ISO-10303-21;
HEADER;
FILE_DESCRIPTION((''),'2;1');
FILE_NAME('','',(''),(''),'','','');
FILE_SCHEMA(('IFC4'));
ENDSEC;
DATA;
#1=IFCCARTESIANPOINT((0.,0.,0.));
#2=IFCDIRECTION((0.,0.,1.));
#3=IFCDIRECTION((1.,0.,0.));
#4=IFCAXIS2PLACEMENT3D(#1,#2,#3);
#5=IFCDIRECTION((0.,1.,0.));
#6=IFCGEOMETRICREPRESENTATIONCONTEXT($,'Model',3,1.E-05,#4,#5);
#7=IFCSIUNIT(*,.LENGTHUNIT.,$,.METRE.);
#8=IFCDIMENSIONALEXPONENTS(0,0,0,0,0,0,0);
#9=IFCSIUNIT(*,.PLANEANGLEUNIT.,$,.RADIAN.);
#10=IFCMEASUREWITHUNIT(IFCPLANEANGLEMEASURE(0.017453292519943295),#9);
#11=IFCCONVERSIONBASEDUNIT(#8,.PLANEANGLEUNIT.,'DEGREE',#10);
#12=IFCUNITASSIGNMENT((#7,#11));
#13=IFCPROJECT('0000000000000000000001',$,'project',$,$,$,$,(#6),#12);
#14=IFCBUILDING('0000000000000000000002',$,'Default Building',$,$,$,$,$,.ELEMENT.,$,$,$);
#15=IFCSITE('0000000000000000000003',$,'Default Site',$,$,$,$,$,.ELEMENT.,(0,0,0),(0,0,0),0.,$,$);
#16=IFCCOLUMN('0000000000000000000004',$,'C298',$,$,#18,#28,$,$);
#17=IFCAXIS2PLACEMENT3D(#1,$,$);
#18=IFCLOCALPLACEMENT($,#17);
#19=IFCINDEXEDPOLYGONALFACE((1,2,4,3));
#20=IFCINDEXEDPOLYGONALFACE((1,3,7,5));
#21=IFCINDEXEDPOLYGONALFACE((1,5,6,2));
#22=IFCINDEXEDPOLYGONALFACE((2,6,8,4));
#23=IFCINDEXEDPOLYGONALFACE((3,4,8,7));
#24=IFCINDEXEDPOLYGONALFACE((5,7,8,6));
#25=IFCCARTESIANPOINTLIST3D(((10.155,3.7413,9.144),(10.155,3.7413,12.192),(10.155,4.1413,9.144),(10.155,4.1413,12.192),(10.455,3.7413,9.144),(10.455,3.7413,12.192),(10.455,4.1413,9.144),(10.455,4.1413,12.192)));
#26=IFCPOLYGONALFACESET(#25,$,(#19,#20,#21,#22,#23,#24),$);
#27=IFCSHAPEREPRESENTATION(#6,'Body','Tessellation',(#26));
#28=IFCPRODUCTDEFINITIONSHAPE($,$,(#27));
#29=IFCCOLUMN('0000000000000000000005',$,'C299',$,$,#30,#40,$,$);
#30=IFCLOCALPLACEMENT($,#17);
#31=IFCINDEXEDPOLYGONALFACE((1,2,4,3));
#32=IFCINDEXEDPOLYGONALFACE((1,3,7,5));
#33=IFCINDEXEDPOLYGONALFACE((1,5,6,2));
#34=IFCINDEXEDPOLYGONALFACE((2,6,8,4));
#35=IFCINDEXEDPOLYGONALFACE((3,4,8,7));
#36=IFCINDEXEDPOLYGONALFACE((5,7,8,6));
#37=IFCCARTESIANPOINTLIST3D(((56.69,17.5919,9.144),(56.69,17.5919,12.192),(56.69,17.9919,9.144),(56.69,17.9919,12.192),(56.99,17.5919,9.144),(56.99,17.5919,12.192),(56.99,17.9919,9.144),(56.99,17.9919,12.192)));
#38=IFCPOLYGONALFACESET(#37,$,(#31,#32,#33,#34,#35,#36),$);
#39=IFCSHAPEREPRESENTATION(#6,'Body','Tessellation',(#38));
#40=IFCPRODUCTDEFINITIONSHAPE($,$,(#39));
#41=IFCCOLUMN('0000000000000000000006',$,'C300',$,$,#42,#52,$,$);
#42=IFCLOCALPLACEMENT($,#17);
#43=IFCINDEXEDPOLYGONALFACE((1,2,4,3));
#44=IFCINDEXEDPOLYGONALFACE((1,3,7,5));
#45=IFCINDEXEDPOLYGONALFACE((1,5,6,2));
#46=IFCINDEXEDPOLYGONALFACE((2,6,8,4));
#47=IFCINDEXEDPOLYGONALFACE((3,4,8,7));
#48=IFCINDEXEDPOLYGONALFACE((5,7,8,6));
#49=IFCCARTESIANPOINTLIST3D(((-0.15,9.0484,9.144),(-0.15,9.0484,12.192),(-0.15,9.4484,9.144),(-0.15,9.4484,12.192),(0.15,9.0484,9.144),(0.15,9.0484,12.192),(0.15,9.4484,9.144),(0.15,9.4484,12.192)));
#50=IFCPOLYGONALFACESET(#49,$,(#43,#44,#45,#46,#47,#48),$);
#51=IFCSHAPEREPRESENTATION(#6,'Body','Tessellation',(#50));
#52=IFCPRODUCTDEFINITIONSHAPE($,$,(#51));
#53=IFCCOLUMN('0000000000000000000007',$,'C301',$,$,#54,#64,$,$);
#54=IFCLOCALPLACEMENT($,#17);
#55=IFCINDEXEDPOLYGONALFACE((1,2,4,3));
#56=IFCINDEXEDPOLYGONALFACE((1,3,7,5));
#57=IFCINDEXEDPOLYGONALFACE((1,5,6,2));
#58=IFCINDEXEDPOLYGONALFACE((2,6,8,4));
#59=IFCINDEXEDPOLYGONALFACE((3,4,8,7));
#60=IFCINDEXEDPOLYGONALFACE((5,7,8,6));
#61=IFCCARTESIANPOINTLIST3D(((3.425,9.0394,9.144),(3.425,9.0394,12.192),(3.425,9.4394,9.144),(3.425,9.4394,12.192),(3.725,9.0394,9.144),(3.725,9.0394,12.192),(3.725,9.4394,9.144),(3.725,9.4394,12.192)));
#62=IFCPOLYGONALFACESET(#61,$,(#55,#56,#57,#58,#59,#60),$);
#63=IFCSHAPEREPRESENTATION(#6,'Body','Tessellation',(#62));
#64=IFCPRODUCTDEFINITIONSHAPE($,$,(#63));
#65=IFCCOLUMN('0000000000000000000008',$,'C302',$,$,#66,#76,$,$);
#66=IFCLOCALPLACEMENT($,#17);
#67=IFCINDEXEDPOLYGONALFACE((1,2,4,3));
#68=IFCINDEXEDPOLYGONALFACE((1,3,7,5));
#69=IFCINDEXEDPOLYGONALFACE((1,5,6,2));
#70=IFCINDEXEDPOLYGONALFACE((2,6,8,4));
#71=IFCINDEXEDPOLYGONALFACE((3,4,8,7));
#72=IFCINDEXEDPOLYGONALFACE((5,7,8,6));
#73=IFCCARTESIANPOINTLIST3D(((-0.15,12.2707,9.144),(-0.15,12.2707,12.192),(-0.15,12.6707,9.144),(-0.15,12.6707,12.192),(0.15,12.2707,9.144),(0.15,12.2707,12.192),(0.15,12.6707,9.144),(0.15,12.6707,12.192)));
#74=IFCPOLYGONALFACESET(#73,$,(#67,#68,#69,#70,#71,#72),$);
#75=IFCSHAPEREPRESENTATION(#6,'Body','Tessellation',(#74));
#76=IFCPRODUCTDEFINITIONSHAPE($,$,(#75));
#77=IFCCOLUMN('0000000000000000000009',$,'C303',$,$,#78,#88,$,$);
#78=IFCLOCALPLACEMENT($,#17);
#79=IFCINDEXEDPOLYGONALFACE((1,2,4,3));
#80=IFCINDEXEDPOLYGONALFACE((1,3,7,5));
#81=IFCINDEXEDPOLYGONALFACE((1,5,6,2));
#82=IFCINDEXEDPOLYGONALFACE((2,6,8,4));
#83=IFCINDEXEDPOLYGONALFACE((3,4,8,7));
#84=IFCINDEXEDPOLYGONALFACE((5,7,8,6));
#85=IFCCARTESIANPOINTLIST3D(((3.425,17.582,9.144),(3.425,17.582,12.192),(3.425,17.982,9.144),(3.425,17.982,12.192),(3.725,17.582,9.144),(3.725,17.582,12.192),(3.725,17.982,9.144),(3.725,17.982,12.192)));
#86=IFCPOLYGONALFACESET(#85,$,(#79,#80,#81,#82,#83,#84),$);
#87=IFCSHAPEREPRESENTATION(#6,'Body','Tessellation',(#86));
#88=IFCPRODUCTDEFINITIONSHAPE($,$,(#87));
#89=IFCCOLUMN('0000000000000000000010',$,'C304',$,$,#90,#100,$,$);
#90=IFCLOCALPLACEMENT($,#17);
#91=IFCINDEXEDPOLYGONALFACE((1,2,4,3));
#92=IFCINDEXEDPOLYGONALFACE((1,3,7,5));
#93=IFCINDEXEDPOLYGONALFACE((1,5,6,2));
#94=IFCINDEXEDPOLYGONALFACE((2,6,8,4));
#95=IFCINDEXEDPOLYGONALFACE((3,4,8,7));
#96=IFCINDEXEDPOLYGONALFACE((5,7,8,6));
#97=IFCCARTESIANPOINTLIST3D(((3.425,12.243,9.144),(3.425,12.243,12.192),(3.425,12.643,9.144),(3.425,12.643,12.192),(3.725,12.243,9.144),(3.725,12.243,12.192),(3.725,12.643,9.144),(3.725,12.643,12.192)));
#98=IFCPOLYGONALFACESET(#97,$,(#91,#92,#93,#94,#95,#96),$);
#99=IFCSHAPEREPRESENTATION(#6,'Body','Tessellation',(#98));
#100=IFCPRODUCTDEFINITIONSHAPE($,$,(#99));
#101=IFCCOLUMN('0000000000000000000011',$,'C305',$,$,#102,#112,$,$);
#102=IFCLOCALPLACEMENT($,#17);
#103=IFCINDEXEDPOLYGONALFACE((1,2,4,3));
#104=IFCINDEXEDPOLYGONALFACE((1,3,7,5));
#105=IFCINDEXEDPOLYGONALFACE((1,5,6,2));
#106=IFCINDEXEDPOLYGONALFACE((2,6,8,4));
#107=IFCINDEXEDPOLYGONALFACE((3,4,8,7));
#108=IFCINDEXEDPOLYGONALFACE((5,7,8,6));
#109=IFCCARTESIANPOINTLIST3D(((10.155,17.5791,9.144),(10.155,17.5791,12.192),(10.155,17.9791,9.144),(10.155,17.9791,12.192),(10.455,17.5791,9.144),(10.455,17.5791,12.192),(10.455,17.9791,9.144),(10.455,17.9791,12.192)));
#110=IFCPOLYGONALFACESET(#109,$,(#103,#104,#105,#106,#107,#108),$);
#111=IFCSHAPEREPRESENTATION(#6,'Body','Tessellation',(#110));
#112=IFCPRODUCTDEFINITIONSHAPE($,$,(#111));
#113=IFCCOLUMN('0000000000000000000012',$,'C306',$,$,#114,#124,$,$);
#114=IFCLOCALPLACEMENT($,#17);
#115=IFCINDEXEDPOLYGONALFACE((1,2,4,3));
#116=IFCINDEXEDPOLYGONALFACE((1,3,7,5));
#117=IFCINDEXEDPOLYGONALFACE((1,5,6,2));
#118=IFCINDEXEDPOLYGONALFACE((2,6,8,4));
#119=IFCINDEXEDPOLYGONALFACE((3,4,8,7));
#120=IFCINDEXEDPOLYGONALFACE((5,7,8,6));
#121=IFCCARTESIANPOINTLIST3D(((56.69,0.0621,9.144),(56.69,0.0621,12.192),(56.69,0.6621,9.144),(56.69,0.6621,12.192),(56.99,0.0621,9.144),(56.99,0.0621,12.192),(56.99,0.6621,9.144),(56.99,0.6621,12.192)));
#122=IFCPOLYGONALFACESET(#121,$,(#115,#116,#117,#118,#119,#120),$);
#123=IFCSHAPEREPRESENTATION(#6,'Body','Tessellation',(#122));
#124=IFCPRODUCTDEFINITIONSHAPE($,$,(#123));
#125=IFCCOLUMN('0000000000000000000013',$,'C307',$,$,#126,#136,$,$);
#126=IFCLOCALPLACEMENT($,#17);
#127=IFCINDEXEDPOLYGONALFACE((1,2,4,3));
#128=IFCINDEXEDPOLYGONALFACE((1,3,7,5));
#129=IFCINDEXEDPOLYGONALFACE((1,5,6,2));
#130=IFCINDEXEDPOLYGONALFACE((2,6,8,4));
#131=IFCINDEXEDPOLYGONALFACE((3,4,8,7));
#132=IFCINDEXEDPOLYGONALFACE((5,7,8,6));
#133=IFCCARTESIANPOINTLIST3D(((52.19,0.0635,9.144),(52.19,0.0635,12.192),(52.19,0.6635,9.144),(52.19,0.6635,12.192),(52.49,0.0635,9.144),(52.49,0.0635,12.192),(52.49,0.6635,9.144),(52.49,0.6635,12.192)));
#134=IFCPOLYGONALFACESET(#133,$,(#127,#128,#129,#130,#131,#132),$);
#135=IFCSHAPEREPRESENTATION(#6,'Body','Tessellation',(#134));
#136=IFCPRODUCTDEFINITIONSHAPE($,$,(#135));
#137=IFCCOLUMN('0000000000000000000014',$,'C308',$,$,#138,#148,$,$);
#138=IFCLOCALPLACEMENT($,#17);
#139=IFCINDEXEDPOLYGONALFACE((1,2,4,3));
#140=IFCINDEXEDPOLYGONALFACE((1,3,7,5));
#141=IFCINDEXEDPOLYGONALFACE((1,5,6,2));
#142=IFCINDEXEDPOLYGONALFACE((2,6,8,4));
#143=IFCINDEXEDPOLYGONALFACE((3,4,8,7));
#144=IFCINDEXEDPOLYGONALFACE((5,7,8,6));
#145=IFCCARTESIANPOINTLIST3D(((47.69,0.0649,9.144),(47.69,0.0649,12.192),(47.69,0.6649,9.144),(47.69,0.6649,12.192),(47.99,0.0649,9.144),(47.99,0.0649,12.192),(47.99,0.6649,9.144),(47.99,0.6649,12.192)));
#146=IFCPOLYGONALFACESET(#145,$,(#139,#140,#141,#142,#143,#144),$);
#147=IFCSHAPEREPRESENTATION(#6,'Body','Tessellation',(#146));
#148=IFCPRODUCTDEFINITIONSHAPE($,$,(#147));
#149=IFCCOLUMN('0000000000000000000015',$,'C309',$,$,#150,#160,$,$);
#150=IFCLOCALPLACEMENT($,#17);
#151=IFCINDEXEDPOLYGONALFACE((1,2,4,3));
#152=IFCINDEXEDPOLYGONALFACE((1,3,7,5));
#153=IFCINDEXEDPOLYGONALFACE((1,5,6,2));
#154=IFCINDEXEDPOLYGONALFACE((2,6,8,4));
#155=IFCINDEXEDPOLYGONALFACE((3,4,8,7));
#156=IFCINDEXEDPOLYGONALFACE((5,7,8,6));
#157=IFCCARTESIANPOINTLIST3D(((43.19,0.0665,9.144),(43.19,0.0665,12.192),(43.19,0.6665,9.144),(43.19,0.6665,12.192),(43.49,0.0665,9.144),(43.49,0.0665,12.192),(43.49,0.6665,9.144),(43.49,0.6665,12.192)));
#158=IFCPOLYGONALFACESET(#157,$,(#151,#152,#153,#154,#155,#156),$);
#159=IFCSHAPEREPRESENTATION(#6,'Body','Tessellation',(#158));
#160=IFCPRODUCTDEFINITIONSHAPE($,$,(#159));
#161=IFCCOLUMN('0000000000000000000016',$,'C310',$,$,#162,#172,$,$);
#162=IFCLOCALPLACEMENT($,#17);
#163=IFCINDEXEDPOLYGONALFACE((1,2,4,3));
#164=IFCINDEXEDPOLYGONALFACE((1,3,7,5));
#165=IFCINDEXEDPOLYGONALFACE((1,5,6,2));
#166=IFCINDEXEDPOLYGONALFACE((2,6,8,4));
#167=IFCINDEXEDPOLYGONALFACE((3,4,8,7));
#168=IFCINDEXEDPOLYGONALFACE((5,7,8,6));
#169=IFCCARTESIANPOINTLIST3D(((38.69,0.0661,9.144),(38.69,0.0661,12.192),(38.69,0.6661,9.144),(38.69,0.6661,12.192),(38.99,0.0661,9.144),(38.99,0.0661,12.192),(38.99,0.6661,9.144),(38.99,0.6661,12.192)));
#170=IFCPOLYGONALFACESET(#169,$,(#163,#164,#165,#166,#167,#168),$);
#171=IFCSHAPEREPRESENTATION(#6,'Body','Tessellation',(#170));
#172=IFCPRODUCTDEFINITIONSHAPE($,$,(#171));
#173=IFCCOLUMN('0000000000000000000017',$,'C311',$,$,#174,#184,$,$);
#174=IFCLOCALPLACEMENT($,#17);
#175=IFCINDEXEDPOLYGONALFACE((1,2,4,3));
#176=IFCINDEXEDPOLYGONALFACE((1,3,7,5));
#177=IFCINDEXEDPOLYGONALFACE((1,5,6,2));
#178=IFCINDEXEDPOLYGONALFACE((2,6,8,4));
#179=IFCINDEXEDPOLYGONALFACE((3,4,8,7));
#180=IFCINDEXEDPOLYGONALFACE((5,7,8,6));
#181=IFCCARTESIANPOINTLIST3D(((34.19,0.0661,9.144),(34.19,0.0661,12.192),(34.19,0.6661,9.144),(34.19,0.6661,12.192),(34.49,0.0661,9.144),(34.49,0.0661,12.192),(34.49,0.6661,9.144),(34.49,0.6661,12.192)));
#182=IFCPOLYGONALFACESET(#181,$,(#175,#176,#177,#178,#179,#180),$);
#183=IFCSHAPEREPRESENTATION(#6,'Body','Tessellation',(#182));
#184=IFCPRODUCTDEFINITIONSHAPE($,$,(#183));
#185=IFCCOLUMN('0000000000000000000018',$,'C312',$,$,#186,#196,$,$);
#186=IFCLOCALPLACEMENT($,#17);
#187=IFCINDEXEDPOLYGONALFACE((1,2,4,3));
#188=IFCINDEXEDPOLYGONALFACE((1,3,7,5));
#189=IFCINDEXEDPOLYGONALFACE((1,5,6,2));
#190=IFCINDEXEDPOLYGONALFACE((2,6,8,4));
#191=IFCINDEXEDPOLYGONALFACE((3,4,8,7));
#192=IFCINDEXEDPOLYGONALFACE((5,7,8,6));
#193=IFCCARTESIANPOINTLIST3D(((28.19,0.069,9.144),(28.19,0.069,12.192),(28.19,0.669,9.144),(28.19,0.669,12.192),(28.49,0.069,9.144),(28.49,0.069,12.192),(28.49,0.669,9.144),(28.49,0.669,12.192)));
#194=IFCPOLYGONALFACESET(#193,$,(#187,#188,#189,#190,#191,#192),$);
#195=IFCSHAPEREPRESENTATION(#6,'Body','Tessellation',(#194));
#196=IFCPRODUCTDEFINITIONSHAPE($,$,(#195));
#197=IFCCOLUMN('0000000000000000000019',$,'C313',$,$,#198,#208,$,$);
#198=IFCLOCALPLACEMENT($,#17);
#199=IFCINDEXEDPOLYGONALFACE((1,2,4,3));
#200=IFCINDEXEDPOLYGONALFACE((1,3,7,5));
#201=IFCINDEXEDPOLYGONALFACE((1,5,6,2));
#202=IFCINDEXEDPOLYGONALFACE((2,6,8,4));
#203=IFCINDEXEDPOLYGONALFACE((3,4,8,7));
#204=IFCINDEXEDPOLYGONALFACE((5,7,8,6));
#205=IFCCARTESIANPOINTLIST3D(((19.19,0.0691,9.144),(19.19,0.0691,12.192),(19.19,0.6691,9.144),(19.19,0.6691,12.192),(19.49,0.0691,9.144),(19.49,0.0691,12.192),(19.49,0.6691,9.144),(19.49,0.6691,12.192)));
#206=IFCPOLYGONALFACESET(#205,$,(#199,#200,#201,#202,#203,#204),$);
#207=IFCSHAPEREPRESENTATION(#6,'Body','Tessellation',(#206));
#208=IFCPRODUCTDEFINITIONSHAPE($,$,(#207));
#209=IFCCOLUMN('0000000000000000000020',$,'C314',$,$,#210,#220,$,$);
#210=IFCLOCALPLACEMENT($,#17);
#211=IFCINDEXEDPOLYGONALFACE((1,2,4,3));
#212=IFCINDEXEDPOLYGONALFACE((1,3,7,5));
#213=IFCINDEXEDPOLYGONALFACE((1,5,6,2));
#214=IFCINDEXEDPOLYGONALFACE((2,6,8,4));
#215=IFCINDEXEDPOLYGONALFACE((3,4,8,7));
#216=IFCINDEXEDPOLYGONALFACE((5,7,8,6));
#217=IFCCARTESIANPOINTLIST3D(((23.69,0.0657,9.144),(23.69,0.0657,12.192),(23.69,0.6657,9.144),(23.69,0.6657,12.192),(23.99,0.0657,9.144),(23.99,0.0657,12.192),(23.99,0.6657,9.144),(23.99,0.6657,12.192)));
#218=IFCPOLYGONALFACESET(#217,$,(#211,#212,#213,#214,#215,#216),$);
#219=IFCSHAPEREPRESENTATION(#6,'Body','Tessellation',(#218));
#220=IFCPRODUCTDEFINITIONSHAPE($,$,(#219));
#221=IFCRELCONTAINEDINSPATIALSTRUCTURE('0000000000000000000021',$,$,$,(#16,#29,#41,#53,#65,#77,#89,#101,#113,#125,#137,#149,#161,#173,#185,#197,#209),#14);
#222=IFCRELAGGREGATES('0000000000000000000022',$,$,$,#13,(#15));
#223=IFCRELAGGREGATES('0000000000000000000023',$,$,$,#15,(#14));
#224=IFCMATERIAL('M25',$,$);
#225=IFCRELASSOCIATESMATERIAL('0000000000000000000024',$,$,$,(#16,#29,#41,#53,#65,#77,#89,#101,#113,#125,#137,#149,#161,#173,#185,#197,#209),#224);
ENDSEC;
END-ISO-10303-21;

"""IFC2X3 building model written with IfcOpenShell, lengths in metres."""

from ifc_helpers import new_model, entity, si_unit, converted_unit, direction, frame, frame_2d, origin_with_axes, place, context, project, spatial, rectangle, extrude, material, element, save


model = new_model("IFC2X3")

# Units and contexts
model_context = context("Model", 3, precision=1e-05, world=origin_with_axes(), true_north=direction((0.0, 1.0, 0.0)))
ifc_project = project(units=[si_unit("LENGTHUNIT", "METRE"), converted_unit("PLANEANGLEUNIT", "DEGREE", entity("IfcPlaneAngleMeasure", 0.017453292519943295), si_unit("PLANEANGLEUNIT", "RADIAN"), dimensions=[0, 0, 0, 0, 0, 0, 0])], contexts=[model_context])

# Site, building
site = spatial("IfcSite", under=ifc_project, Name="Default Site", CompositionType="ELEMENT", RefLatitude=(0, 0, 0), RefLongitude=(0, 0, 0), RefElevation=0.0)
building = spatial("IfcBuilding", under=site, Name="Default Building", CompositionType="ELEMENT")

# Columns
ifc_material = material(Name="M25")
placement = place(None, origin_with_axes())
element("IfcColumn", 1, at=placement, inside=building, material=ifc_material, Name="C298", context=model_context, shape_type="SweptSolid", body=[
    extrude(rectangle(XDim=0.3, YDim=0.4, at=frame_2d((0.0, 0.0), x_axis=(1.0, 0.0, 0.0))), frame((10.305, 3.9413, 9.144), z_axis=(0.0, 0.0, 1.0), x_axis=(1.0, 0.0, 0.0)), (0.0, 0.0, 1.0), 3.048),
])
element("IfcColumn", 2, at=placement, inside=building, material=ifc_material, Name="C299", context=model_context, shape_type="SweptSolid", body=[
    extrude(rectangle(XDim=0.3, YDim=0.4, at=frame_2d((0.0, 0.0), x_axis=(1.0, 0.0, 0.0))), frame((56.84, 17.7919, 9.144), z_axis=(0.0, 0.0, 1.0), x_axis=(1.0, 0.0, 0.0)), (0.0, 0.0, 1.0), 3.048),
])
element("IfcColumn", 3, at=placement, inside=building, material=ifc_material, Name="C300", context=model_context, shape_type="SweptSolid", body=[
    extrude(rectangle(XDim=0.3, YDim=0.4, at=frame_2d((0.0, 0.0), x_axis=(1.0, 0.0, 0.0))), frame((0.0, 9.2484, 9.144), z_axis=(0.0, 0.0, 1.0), x_axis=(1.0, 0.0, 0.0)), (0.0, 0.0, 1.0), 3.048),
])
element("IfcColumn", 4, at=placement, inside=building, material=ifc_material, Name="C301", context=model_context, shape_type="SweptSolid", body=[
    extrude(rectangle(XDim=0.3, YDim=0.4, at=frame_2d((0.0, 0.0), x_axis=(1.0, 0.0, 0.0))), frame((3.575, 9.2394, 9.144), z_axis=(0.0, 0.0, 1.0), x_axis=(1.0, 0.0, 0.0)), (0.0, 0.0, 1.0), 3.048),
])
element("IfcColumn", 5, at=placement, inside=building, material=ifc_material, Name="C302", context=model_context, shape_type="SweptSolid", body=[
    extrude(rectangle(XDim=0.3, YDim=0.4, at=frame_2d((0.0, 0.0), x_axis=(1.0, 0.0, 0.0))), frame((0.0, 12.4707, 9.144), z_axis=(0.0, 0.0, 1.0), x_axis=(1.0, 0.0, 0.0)), (0.0, 0.0, 1.0), 3.048),
])
element("IfcColumn", 6, at=placement, inside=building, material=ifc_material, Name="C303", context=model_context, shape_type="SweptSolid", body=[
    extrude(rectangle(XDim=0.3, YDim=0.4, at=frame_2d((0.0, 0.0), x_axis=(1.0, 0.0, 0.0))), frame((3.575, 17.782, 9.144), z_axis=(0.0, 0.0, 1.0), x_axis=(1.0, 0.0, 0.0)), (0.0, 0.0, 1.0), 3.048),
])
element("IfcColumn", 7, at=placement, inside=building, material=ifc_material, Name="C304", context=model_context, shape_type="SweptSolid", body=[
    extrude(rectangle(XDim=0.3, YDim=0.4, at=frame_2d((0.0, 0.0), x_axis=(1.0, 0.0, 0.0))), frame((3.575, 12.443, 9.144), z_axis=(0.0, 0.0, 1.0), x_axis=(1.0, 0.0, 0.0)), (0.0, 0.0, 1.0), 3.048),
])
element("IfcColumn", 8, at=placement, inside=building, material=ifc_material, Name="C305", context=model_context, shape_type="SweptSolid", body=[
    extrude(rectangle(XDim=0.3, YDim=0.4, at=frame_2d((0.0, 0.0), x_axis=(1.0, 0.0, 0.0))), frame((10.305, 17.7791, 9.144), z_axis=(0.0, 0.0, 1.0), x_axis=(1.0, 0.0, 0.0)), (0.0, 0.0, 1.0), 3.048),
])
element("IfcColumn", 9, at=placement, inside=building, material=ifc_material, Name="C306", context=model_context, shape_type="SweptSolid", body=[
    extrude(rectangle(XDim=0.3, YDim=0.6, at=frame_2d((0.0, 0.0), x_axis=(1.0, 0.0, 0.0))), frame((56.84, 0.3621, 9.144), z_axis=(0.0, 0.0, 1.0), x_axis=(1.0, 0.0, 0.0)), (0.0, 0.0, 1.0), 3.048),
])
element("IfcColumn", 10, at=placement, inside=building, material=ifc_material, Name="C307", context=model_context, shape_type="SweptSolid", body=[
    extrude(rectangle(XDim=0.3, YDim=0.6, at=frame_2d((0.0, 0.0), x_axis=(1.0, 0.0, 0.0))), frame((52.34, 0.3635, 9.144), z_axis=(0.0, 0.0, 1.0), x_axis=(1.0, 0.0, 0.0)), (0.0, 0.0, 1.0), 3.048),
])
element("IfcColumn", 11, at=placement, inside=building, material=ifc_material, Name="C308", context=model_context, shape_type="SweptSolid", body=[
    extrude(rectangle(XDim=0.3, YDim=0.6, at=frame_2d((0.0, 0.0), x_axis=(1.0, 0.0, 0.0))), frame((47.84, 0.3649, 9.144), z_axis=(0.0, 0.0, 1.0), x_axis=(1.0, 0.0, 0.0)), (0.0, 0.0, 1.0), 3.048),
])
element("IfcColumn", 12, at=placement, inside=building, material=ifc_material, Name="C309", context=model_context, shape_type="SweptSolid", body=[
    extrude(rectangle(XDim=0.3, YDim=0.6, at=frame_2d((0.0, 0.0), x_axis=(1.0, 0.0, 0.0))), frame((43.34, 0.3665, 9.144), z_axis=(0.0, 0.0, 1.0), x_axis=(1.0, 0.0, 0.0)), (0.0, 0.0, 1.0), 3.048),
])
element("IfcColumn", 13, at=placement, inside=building, material=ifc_material, Name="C310", context=model_context, shape_type="SweptSolid", body=[
    extrude(rectangle(XDim=0.3, YDim=0.6, at=frame_2d((0.0, 0.0), x_axis=(1.0, 0.0, 0.0))), frame((38.84, 0.3661, 9.144), z_axis=(0.0, 0.0, 1.0), x_axis=(1.0, 0.0, 0.0)), (0.0, 0.0, 1.0), 3.048),
])
element("IfcColumn", 14, at=placement, inside=building, material=ifc_material, Name="C311", context=model_context, shape_type="SweptSolid", body=[
    extrude(rectangle(XDim=0.3, YDim=0.6, at=frame_2d((0.0, 0.0), x_axis=(1.0, 0.0, 0.0))), frame((34.34, 0.3661, 9.144), z_axis=(0.0, 0.0, 1.0), x_axis=(1.0, 0.0, 0.0)), (0.0, 0.0, 1.0), 3.048),
])
element("IfcColumn", 15, at=placement, inside=building, material=ifc_material, Name="C312", context=model_context, shape_type="SweptSolid", body=[
    extrude(rectangle(XDim=0.3, YDim=0.6, at=frame_2d((0.0, 0.0), x_axis=(1.0, 0.0, 0.0))), frame((28.34, 0.369, 9.144), z_axis=(0.0, 0.0, 1.0), x_axis=(1.0, 0.0, 0.0)), (0.0, 0.0, 1.0), 3.048),
])
element("IfcColumn", 16, at=placement, inside=building, material=ifc_material, Name="C313", context=model_context, shape_type="SweptSolid", body=[
    extrude(rectangle(XDim=0.3, YDim=0.6, at=frame_2d((0.0, 0.0), x_axis=(1.0, 0.0, 0.0))), frame((19.34, 0.3691, 9.144), z_axis=(0.0, 0.0, 1.0), x_axis=(1.0, 0.0, 0.0)), (0.0, 0.0, 1.0), 3.048),
])
element("IfcColumn", 17, at=placement, inside=building, material=ifc_material, Name="C314", context=model_context, shape_type="SweptSolid", body=[
    extrude(rectangle(XDim=0.3, YDim=0.6, at=frame_2d((0.0, 0.0), x_axis=(1.0, 0.0, 0.0))), frame((23.84, 0.3657, 9.144), z_axis=(0.0, 0.0, 1.0), x_axis=(1.0, 0.0, 0.0)), (0.0, 0.0, 1.0), 3.048),
])

save(model, "model.ifc")
